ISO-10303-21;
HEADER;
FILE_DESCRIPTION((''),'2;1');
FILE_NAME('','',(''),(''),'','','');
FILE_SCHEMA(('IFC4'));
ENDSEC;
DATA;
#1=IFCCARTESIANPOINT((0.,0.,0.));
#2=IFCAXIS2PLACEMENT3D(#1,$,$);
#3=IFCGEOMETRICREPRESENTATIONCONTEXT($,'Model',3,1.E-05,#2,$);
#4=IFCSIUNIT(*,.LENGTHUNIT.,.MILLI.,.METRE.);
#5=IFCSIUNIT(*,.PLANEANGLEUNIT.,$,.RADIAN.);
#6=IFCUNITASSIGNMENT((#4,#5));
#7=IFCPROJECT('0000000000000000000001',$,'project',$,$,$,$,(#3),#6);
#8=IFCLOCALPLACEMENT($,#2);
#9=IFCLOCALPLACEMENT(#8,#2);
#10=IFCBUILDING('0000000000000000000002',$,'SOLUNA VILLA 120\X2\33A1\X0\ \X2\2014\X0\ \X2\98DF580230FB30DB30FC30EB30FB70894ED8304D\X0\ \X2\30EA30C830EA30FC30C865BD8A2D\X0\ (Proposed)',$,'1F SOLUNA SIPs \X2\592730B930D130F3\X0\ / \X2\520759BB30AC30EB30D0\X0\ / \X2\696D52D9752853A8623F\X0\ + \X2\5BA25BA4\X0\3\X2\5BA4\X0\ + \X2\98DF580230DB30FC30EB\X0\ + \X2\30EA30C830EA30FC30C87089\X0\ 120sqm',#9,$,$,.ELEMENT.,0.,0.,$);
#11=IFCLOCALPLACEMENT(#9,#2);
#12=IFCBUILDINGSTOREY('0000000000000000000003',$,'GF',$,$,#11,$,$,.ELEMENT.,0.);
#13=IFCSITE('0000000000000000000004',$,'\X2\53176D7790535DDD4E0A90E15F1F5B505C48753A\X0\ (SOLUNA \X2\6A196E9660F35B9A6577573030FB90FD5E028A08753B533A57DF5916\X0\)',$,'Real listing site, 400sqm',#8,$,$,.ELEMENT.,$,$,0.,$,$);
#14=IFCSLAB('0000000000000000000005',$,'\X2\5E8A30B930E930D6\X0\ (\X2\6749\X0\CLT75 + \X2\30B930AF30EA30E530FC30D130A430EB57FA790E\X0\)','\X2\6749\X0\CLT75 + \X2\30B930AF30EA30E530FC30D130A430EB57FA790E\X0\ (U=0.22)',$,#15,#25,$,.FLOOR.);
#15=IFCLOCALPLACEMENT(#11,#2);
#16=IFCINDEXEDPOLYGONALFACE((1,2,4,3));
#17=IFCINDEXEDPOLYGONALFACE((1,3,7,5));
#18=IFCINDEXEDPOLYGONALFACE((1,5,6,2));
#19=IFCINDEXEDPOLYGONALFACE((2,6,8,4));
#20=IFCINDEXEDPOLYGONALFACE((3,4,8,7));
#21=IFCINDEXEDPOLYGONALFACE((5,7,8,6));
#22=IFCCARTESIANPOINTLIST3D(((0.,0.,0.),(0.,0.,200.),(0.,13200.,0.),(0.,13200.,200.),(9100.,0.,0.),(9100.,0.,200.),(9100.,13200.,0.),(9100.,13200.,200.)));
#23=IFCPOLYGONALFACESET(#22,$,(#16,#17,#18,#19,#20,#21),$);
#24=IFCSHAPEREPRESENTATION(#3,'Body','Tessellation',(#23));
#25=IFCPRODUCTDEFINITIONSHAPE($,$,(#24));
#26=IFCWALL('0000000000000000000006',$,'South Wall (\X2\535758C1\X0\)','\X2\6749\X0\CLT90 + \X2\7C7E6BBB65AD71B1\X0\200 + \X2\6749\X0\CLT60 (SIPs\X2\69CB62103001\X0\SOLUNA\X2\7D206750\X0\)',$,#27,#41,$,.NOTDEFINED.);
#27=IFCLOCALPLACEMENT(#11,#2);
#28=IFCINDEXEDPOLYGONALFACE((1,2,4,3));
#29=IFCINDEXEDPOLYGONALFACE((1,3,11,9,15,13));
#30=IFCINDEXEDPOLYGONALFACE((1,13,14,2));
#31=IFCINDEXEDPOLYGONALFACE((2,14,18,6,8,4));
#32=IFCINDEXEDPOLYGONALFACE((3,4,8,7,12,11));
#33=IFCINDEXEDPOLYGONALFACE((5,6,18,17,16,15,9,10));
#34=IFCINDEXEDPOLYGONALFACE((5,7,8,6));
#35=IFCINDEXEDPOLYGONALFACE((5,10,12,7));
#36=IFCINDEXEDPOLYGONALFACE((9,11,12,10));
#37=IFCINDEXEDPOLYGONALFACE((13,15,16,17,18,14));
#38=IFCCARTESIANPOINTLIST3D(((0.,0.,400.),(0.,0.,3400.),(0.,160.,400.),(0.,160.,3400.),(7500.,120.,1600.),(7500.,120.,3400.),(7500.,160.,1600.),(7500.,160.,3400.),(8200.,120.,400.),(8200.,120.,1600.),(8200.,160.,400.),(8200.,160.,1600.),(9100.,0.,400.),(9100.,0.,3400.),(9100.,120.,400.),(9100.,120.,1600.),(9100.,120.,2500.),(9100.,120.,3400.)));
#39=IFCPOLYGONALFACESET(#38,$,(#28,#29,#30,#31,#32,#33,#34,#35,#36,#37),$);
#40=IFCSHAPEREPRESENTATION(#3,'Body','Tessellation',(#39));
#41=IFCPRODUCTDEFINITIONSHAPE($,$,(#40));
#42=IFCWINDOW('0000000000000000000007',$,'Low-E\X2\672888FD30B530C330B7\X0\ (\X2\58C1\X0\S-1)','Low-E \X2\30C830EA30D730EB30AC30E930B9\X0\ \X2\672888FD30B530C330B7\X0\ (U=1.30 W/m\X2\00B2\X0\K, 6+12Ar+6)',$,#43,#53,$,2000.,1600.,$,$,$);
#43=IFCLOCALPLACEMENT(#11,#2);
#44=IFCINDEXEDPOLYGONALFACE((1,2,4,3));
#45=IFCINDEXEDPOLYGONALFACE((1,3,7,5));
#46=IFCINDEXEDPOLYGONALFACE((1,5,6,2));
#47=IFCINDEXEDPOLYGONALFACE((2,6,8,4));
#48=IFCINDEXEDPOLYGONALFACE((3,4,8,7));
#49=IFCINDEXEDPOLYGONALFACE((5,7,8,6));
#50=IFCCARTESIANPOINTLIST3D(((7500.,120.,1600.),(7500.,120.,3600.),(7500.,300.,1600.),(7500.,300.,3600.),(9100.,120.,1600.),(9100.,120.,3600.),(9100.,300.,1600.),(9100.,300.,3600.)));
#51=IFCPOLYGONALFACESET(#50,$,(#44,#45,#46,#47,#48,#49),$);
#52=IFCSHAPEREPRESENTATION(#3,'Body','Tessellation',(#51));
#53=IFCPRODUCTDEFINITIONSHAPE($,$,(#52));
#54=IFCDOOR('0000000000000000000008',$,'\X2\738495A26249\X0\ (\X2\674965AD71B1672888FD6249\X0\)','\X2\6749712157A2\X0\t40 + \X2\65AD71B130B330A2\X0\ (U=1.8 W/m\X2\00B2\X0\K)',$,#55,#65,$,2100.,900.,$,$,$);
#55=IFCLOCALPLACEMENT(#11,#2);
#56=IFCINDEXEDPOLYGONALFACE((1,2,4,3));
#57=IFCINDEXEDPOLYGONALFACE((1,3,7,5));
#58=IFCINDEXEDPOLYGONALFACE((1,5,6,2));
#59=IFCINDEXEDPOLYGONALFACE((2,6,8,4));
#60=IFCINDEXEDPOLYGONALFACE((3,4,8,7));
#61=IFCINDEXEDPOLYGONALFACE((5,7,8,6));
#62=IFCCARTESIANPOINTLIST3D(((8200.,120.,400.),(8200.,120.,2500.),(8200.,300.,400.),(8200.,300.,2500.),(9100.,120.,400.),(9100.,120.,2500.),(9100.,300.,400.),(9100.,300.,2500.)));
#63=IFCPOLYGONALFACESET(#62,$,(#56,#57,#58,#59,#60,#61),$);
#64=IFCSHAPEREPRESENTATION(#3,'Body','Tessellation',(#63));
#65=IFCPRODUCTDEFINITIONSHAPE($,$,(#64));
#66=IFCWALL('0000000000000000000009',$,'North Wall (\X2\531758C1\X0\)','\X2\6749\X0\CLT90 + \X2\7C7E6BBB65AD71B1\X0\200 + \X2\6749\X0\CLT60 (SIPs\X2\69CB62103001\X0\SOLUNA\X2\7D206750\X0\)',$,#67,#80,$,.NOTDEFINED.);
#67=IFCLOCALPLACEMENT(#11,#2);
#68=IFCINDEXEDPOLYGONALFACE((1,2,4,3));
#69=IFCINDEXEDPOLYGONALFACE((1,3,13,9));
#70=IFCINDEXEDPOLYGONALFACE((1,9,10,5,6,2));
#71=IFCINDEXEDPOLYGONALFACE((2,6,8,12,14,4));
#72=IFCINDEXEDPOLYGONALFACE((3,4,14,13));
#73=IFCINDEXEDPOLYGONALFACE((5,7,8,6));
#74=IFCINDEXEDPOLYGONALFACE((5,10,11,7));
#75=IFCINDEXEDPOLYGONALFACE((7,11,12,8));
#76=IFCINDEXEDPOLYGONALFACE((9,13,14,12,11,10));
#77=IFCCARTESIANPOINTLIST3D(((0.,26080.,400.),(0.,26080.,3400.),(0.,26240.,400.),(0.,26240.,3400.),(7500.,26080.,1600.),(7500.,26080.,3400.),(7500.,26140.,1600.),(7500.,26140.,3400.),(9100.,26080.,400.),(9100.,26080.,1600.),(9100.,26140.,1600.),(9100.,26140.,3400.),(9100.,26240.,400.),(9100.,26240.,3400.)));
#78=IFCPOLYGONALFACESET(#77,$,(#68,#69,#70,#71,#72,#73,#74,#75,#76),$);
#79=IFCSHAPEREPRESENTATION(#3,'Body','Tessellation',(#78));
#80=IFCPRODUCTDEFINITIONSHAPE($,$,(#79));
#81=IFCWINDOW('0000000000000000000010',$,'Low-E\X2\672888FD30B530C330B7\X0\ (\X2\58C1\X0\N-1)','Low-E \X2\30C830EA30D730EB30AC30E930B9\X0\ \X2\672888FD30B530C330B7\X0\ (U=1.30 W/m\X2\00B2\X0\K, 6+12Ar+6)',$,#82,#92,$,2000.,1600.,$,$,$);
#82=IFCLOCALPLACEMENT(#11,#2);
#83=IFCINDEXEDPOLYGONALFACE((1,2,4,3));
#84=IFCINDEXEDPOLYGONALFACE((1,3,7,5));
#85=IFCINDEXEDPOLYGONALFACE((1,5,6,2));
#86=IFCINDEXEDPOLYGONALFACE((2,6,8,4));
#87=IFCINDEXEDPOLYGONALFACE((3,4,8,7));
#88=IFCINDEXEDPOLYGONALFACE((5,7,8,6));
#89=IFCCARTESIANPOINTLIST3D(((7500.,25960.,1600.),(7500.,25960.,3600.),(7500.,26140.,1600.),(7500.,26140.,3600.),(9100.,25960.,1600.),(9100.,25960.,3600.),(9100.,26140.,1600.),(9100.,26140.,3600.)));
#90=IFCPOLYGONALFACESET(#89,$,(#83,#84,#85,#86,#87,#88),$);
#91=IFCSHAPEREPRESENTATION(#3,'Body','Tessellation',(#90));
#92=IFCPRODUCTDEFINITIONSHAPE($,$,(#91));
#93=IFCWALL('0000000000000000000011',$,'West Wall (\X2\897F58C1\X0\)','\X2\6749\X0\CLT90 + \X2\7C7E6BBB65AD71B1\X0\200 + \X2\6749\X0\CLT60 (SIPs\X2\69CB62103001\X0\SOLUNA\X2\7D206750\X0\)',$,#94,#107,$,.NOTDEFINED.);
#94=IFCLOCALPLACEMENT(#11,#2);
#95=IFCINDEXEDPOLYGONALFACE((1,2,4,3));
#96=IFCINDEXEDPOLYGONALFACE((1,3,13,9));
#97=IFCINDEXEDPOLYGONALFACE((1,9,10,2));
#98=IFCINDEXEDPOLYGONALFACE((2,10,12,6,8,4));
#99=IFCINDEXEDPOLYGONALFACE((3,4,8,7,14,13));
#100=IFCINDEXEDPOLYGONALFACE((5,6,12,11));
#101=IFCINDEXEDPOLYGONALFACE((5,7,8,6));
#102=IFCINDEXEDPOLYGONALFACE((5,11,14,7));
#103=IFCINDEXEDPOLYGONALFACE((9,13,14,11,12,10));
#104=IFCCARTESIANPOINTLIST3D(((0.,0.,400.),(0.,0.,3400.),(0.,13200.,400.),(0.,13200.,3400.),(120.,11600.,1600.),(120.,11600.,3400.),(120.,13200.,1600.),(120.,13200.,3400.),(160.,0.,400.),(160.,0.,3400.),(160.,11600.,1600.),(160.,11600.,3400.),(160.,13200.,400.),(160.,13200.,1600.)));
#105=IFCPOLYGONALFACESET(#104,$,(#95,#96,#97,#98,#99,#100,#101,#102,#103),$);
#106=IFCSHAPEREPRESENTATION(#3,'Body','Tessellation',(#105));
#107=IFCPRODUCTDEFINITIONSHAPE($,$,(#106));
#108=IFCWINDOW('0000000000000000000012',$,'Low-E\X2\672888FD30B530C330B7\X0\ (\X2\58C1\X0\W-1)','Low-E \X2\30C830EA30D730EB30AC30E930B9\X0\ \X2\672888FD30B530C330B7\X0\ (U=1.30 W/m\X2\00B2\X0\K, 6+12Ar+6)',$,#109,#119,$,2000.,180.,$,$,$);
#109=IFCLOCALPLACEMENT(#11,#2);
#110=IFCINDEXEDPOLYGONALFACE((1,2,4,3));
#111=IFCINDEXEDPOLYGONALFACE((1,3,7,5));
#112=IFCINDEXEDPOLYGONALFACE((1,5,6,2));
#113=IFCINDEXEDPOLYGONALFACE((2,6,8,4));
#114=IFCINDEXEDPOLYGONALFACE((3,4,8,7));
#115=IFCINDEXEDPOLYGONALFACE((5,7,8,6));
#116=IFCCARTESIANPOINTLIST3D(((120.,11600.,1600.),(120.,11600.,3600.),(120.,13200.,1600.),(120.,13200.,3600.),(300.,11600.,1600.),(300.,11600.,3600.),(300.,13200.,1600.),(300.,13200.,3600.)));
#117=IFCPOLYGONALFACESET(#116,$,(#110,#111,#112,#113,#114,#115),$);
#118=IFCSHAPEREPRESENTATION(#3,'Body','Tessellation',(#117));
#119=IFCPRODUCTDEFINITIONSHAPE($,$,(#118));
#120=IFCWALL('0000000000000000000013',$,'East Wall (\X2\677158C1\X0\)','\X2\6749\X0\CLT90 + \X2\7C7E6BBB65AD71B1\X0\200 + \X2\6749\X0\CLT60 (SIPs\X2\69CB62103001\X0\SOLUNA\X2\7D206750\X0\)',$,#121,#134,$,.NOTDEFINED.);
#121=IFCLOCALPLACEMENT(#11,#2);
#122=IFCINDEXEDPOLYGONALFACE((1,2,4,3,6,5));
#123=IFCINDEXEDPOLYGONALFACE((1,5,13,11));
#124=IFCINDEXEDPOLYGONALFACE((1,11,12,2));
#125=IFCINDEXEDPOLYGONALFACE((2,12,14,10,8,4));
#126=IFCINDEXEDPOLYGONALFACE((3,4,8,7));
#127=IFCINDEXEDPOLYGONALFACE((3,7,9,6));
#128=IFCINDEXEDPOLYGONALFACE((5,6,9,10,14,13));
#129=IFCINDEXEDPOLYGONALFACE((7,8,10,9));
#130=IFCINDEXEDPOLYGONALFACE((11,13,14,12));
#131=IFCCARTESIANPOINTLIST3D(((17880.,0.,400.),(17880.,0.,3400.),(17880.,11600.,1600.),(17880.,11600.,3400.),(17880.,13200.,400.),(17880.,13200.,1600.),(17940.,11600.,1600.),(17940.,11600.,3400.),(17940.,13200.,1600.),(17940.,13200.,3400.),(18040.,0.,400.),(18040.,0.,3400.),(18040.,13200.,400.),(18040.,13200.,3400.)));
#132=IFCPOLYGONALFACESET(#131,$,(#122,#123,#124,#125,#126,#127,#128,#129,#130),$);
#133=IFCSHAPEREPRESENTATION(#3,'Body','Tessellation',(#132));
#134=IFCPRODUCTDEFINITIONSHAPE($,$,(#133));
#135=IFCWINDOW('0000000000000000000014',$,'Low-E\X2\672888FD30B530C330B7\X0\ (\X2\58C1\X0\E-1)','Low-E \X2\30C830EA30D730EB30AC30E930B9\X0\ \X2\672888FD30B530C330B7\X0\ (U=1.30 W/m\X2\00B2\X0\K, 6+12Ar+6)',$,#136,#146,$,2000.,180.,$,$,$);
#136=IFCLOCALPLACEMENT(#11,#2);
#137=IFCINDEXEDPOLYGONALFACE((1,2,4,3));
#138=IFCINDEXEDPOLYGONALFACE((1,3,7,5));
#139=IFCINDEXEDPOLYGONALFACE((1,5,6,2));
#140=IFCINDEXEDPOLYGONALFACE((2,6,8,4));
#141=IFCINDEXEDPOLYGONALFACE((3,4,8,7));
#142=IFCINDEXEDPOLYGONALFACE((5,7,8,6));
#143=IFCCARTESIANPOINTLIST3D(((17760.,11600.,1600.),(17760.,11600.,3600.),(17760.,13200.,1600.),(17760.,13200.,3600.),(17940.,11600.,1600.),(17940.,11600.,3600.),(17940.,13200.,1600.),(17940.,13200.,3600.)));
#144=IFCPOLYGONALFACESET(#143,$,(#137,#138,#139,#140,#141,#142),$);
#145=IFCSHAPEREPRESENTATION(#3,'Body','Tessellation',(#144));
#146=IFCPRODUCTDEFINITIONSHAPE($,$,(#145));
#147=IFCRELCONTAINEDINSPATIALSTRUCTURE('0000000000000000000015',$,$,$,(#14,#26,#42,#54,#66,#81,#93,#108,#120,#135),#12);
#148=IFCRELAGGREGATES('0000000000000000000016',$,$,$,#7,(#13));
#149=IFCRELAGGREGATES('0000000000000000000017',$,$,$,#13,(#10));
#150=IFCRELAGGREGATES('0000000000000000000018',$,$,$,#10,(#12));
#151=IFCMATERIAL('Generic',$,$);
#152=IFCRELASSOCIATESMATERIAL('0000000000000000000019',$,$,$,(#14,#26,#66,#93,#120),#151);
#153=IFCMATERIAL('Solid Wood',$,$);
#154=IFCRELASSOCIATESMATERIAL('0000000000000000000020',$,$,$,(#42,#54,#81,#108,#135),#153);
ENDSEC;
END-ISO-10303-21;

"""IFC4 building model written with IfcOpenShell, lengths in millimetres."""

from ifc_helpers import new_model, si_unit, frame, frame_2d, origin, place, context, project, spatial, rectangle, extrude, material, element, fill, save


model = new_model("IFC4")

# Units and contexts
model_context = context("Model", 3, precision=1e-05, world=origin())
ifc_project = project(units=[si_unit("LENGTHUNIT", "METRE", prefix="MILLI"), si_unit("PLANEANGLEUNIT", "RADIAN")], contexts=[model_context])

# Site, building, storey
site_placement = place(None, origin())
site = spatial("IfcSite", under=ifc_project, at=site_placement, Name="北海道川上郡弟子屈町 (SOLUNA 標準想定敷地・都市計画区域外)", ObjectType="Real listing site, 400sqm", CompositionType="ELEMENT", RefElevation=0.0)
building_placement = place(site_placement, origin())
building = spatial("IfcBuilding", under=site, at=building_placement, Name="SOLUNA VILLA 120㎡ — 食堂・ホール・炉付き リトリート施設 (Proposed)", ObjectType="1F SOLUNA SIPs 大スパン / 切妻ガルバ / 業務用厨房 + 客室3室 + 食堂ホール + リトリート炉 120sqm", CompositionType="ELEMENT", ElevationOfRefHeight=0.0, ElevationOfTerrain=0.0)
storey_placement = place(building_placement, origin())
storey = spatial("IfcBuildingStorey", under=building, at=storey_placement, Name="GF", CompositionType="ELEMENT", Elevation=0.0)

# Slab
ifc_material_1 = material(Name="Generic")
slab_placement = place(storey_placement, origin())
element("IfcSlab", 1, at=slab_placement, inside=storey, material=ifc_material_1, Name="床スラブ (杉CLT75 + スクリューパイル基礎)", Description="杉CLT75 + スクリューパイル基礎 (U=0.22)", PredefinedType="FLOOR", context=model_context, shape_type="SweptSolid", body=[
    extrude(rectangle(XDim=9100.0, YDim=13200.0, at=frame_2d((4550.0, 6600.0))), origin(), (0.0, 0.0, 1.0), 200.0),
])

# Wall, openings, window, door
wall_1_placement = place(storey_placement, frame((0.0, 0.0, 200.0)))
wall_1 = element("IfcWall", 2, at=wall_1_placement, inside=storey, material=ifc_material_1, Name="South Wall (南壁)", Description="杉CLT90 + 籾殻断熱200 + 杉CLT60 (SIPs構成、SOLUNA素材)", PredefinedType="NOTDEFINED", context=model_context, shape_type="SweptSolid", body=[
    extrude(rectangle(XDim=9100.0, YDim=160.0, at=frame_2d((4550.0, 80.0))), frame((0.0, 0.0, 200.0)), (0.0, 0.0, 1.0), 3000.0),
])
opening_1_placement = place(storey_placement, frame((3750.0, 60.0, 800.0)))
opening_1 = element("IfcOpeningElement", 3, at=opening_1_placement, cuts=wall_1, PredefinedType="NOTDEFINED", context=model_context, shape_type="SweptSolid", body=[
    extrude(rectangle(XDim=1600.0, YDim=180.0, at=frame_2d((800.0, 90.0))), frame((3750.0, 60.0, 800.0)), (0.0, 0.0, 1.0), 2000.0),
])
opening_2_placement = place(storey_placement, frame((4100.0, 60.0, 200.0)))
opening_2 = element("IfcOpeningElement", 4, at=opening_2_placement, cuts=wall_1, PredefinedType="NOTDEFINED", context=model_context, shape_type="SweptSolid", body=[
    extrude(rectangle(XDim=900.0, YDim=180.0, at=frame_2d((450.0, 90.0))), frame((4100.0, 60.0, 200.0)), (0.0, 0.0, 1.0), 2100.0),
])
ifc_material_2 = material(Name="Solid Wood")
window_1_placement = place(storey_placement, frame((3750.0, 60.0, 800.0)))
window_1 = element("IfcWindow", 5, at=window_1_placement, inside=storey, material=ifc_material_2, Name="Low-E木製サッシ (壁S-1)", Description="Low-E トリプルガラス 木製サッシ (U=1.30 W/m²K, 6+12Ar+6)", OverallHeight=2000.0, OverallWidth=1600.0, context=model_context, shape_type="SweptSolid", body=[
    extrude(rectangle(XDim=1600.0, YDim=180.0, at=frame_2d((800.0, 90.0))), frame((3750.0, 60.0, 800.0)), (0.0, 0.0, 1.0), 2000.0),
])
fill(opening_1, window_1)
door_placement = place(storey_placement, frame((4100.0, 60.0, 200.0)))
door = element("IfcDoor", 6, at=door_placement, inside=storey, material=ifc_material_2, Name="玄関扉 (杉断熱木製扉)", Description="杉無垢t40 + 断熱コア (U=1.8 W/m²K)", OverallHeight=2100.0, OverallWidth=900.0, context=model_context, shape_type="SweptSolid", body=[
    extrude(rectangle(XDim=900.0, YDim=180.0, at=frame_2d((450.0, 90.0))), frame((4100.0, 60.0, 200.0)), (0.0, 0.0, 1.0), 2100.0),
])
fill(opening_2, door)

# Walls, openings, windows
wall_2_placement = place(storey_placement, frame((0.0, 13040.0, 200.0)))
wall_2 = element("IfcWall", 7, at=wall_2_placement, inside=storey, material=ifc_material_1, Name="North Wall (北壁)", Description="杉CLT90 + 籾殻断熱200 + 杉CLT60 (SIPs構成、SOLUNA素材)", PredefinedType="NOTDEFINED", context=model_context, shape_type="SweptSolid", body=[
    extrude(rectangle(XDim=9100.0, YDim=160.0, at=frame_2d((4550.0, 80.0))), frame((0.0, 13040.0, 200.0)), (0.0, 0.0, 1.0), 3000.0),
])
opening_3_placement = place(storey_placement, frame((3750.0, 12980.0, 800.0)))
opening_3 = element("IfcOpeningElement", 8, at=opening_3_placement, cuts=wall_2, PredefinedType="NOTDEFINED", context=model_context, shape_type="SweptSolid", body=[
    extrude(rectangle(XDim=1600.0, YDim=180.0, at=frame_2d((800.0, 90.0))), frame((3750.0, 12980.0, 800.0)), (0.0, 0.0, 1.0), 2000.0),
])
window_2_placement = place(storey_placement, frame((3750.0, 12980.0, 800.0)))
window_2 = element("IfcWindow", 9, at=window_2_placement, inside=storey, material=ifc_material_2, Name="Low-E木製サッシ (壁N-1)", Description="Low-E トリプルガラス 木製サッシ (U=1.30 W/m²K, 6+12Ar+6)", OverallHeight=2000.0, OverallWidth=1600.0, context=model_context, shape_type="SweptSolid", body=[
    extrude(rectangle(XDim=1600.0, YDim=180.0, at=frame_2d((800.0, 90.0))), frame((3750.0, 12980.0, 800.0)), (0.0, 0.0, 1.0), 2000.0),
])
fill(opening_3, window_2)
wall_3_placement = place(storey_placement, frame((0.0, 0.0, 200.0)))
wall_3 = element("IfcWall", 10, at=wall_3_placement, inside=storey, material=ifc_material_1, Name="West Wall (西壁)", Description="杉CLT90 + 籾殻断熱200 + 杉CLT60 (SIPs構成、SOLUNA素材)", PredefinedType="NOTDEFINED", context=model_context, shape_type="SweptSolid", body=[
    extrude(rectangle(XDim=160.0, YDim=13200.0, at=frame_2d((80.0, 6600.0))), frame((0.0, 0.0, 200.0)), (0.0, 0.0, 1.0), 3000.0),
])
opening_4_placement = place(storey_placement, frame((60.0, 5800.0, 800.0)))
opening_4 = element("IfcOpeningElement", 11, at=opening_4_placement, cuts=wall_3, PredefinedType="NOTDEFINED", context=model_context, shape_type="SweptSolid", body=[
    extrude(rectangle(XDim=180.0, YDim=1600.0, at=frame_2d((90.0, 800.0))), frame((60.0, 5800.0, 800.0)), (0.0, 0.0, 1.0), 2000.0),
])
window_3_placement = place(storey_placement, frame((60.0, 5800.0, 800.0)))
window_3 = element("IfcWindow", 12, at=window_3_placement, inside=storey, material=ifc_material_2, Name="Low-E木製サッシ (壁W-1)", Description="Low-E トリプルガラス 木製サッシ (U=1.30 W/m²K, 6+12Ar+6)", OverallHeight=2000.0, OverallWidth=180.0, context=model_context, shape_type="SweptSolid", body=[
    extrude(rectangle(XDim=180.0, YDim=1600.0, at=frame_2d((90.0, 800.0))), frame((60.0, 5800.0, 800.0)), (0.0, 0.0, 1.0), 2000.0),
])
fill(opening_4, window_3)
wall_4_placement = place(storey_placement, frame((8940.0, 0.0, 200.0)))
wall_4 = element("IfcWall", 13, at=wall_4_placement, inside=storey, material=ifc_material_1, Name="East Wall (東壁)", Description="杉CLT90 + 籾殻断熱200 + 杉CLT60 (SIPs構成、SOLUNA素材)", PredefinedType="NOTDEFINED", context=model_context, shape_type="SweptSolid", body=[
    extrude(rectangle(XDim=160.0, YDim=13200.0, at=frame_2d((80.0, 6600.0))), frame((8940.0, 0.0, 200.0)), (0.0, 0.0, 1.0), 3000.0),
])
opening_5_placement = place(storey_placement, frame((8880.0, 5800.0, 800.0)))
opening_5 = element("IfcOpeningElement", 14, at=opening_5_placement, cuts=wall_4, PredefinedType="NOTDEFINED", context=model_context, shape_type="SweptSolid", body=[
    extrude(rectangle(XDim=180.0, YDim=1600.0, at=frame_2d((90.0, 800.0))), frame((8880.0, 5800.0, 800.0)), (0.0, 0.0, 1.0), 2000.0),
])
window_4_placement = place(storey_placement, frame((8880.0, 5800.0, 800.0)))
window_4 = element("IfcWindow", 15, at=window_4_placement, inside=storey, material=ifc_material_2, Name="Low-E木製サッシ (壁E-1)", Description="Low-E トリプルガラス 木製サッシ (U=1.30 W/m²K, 6+12Ar+6)", OverallHeight=2000.0, OverallWidth=180.0, context=model_context, shape_type="SweptSolid", body=[
    extrude(rectangle(XDim=180.0, YDim=1600.0, at=frame_2d((90.0, 800.0))), frame((8880.0, 5800.0, 800.0)), (0.0, 0.0, 1.0), 2000.0),
])
fill(opening_5, window_4)

save(model, "model.ifc")
